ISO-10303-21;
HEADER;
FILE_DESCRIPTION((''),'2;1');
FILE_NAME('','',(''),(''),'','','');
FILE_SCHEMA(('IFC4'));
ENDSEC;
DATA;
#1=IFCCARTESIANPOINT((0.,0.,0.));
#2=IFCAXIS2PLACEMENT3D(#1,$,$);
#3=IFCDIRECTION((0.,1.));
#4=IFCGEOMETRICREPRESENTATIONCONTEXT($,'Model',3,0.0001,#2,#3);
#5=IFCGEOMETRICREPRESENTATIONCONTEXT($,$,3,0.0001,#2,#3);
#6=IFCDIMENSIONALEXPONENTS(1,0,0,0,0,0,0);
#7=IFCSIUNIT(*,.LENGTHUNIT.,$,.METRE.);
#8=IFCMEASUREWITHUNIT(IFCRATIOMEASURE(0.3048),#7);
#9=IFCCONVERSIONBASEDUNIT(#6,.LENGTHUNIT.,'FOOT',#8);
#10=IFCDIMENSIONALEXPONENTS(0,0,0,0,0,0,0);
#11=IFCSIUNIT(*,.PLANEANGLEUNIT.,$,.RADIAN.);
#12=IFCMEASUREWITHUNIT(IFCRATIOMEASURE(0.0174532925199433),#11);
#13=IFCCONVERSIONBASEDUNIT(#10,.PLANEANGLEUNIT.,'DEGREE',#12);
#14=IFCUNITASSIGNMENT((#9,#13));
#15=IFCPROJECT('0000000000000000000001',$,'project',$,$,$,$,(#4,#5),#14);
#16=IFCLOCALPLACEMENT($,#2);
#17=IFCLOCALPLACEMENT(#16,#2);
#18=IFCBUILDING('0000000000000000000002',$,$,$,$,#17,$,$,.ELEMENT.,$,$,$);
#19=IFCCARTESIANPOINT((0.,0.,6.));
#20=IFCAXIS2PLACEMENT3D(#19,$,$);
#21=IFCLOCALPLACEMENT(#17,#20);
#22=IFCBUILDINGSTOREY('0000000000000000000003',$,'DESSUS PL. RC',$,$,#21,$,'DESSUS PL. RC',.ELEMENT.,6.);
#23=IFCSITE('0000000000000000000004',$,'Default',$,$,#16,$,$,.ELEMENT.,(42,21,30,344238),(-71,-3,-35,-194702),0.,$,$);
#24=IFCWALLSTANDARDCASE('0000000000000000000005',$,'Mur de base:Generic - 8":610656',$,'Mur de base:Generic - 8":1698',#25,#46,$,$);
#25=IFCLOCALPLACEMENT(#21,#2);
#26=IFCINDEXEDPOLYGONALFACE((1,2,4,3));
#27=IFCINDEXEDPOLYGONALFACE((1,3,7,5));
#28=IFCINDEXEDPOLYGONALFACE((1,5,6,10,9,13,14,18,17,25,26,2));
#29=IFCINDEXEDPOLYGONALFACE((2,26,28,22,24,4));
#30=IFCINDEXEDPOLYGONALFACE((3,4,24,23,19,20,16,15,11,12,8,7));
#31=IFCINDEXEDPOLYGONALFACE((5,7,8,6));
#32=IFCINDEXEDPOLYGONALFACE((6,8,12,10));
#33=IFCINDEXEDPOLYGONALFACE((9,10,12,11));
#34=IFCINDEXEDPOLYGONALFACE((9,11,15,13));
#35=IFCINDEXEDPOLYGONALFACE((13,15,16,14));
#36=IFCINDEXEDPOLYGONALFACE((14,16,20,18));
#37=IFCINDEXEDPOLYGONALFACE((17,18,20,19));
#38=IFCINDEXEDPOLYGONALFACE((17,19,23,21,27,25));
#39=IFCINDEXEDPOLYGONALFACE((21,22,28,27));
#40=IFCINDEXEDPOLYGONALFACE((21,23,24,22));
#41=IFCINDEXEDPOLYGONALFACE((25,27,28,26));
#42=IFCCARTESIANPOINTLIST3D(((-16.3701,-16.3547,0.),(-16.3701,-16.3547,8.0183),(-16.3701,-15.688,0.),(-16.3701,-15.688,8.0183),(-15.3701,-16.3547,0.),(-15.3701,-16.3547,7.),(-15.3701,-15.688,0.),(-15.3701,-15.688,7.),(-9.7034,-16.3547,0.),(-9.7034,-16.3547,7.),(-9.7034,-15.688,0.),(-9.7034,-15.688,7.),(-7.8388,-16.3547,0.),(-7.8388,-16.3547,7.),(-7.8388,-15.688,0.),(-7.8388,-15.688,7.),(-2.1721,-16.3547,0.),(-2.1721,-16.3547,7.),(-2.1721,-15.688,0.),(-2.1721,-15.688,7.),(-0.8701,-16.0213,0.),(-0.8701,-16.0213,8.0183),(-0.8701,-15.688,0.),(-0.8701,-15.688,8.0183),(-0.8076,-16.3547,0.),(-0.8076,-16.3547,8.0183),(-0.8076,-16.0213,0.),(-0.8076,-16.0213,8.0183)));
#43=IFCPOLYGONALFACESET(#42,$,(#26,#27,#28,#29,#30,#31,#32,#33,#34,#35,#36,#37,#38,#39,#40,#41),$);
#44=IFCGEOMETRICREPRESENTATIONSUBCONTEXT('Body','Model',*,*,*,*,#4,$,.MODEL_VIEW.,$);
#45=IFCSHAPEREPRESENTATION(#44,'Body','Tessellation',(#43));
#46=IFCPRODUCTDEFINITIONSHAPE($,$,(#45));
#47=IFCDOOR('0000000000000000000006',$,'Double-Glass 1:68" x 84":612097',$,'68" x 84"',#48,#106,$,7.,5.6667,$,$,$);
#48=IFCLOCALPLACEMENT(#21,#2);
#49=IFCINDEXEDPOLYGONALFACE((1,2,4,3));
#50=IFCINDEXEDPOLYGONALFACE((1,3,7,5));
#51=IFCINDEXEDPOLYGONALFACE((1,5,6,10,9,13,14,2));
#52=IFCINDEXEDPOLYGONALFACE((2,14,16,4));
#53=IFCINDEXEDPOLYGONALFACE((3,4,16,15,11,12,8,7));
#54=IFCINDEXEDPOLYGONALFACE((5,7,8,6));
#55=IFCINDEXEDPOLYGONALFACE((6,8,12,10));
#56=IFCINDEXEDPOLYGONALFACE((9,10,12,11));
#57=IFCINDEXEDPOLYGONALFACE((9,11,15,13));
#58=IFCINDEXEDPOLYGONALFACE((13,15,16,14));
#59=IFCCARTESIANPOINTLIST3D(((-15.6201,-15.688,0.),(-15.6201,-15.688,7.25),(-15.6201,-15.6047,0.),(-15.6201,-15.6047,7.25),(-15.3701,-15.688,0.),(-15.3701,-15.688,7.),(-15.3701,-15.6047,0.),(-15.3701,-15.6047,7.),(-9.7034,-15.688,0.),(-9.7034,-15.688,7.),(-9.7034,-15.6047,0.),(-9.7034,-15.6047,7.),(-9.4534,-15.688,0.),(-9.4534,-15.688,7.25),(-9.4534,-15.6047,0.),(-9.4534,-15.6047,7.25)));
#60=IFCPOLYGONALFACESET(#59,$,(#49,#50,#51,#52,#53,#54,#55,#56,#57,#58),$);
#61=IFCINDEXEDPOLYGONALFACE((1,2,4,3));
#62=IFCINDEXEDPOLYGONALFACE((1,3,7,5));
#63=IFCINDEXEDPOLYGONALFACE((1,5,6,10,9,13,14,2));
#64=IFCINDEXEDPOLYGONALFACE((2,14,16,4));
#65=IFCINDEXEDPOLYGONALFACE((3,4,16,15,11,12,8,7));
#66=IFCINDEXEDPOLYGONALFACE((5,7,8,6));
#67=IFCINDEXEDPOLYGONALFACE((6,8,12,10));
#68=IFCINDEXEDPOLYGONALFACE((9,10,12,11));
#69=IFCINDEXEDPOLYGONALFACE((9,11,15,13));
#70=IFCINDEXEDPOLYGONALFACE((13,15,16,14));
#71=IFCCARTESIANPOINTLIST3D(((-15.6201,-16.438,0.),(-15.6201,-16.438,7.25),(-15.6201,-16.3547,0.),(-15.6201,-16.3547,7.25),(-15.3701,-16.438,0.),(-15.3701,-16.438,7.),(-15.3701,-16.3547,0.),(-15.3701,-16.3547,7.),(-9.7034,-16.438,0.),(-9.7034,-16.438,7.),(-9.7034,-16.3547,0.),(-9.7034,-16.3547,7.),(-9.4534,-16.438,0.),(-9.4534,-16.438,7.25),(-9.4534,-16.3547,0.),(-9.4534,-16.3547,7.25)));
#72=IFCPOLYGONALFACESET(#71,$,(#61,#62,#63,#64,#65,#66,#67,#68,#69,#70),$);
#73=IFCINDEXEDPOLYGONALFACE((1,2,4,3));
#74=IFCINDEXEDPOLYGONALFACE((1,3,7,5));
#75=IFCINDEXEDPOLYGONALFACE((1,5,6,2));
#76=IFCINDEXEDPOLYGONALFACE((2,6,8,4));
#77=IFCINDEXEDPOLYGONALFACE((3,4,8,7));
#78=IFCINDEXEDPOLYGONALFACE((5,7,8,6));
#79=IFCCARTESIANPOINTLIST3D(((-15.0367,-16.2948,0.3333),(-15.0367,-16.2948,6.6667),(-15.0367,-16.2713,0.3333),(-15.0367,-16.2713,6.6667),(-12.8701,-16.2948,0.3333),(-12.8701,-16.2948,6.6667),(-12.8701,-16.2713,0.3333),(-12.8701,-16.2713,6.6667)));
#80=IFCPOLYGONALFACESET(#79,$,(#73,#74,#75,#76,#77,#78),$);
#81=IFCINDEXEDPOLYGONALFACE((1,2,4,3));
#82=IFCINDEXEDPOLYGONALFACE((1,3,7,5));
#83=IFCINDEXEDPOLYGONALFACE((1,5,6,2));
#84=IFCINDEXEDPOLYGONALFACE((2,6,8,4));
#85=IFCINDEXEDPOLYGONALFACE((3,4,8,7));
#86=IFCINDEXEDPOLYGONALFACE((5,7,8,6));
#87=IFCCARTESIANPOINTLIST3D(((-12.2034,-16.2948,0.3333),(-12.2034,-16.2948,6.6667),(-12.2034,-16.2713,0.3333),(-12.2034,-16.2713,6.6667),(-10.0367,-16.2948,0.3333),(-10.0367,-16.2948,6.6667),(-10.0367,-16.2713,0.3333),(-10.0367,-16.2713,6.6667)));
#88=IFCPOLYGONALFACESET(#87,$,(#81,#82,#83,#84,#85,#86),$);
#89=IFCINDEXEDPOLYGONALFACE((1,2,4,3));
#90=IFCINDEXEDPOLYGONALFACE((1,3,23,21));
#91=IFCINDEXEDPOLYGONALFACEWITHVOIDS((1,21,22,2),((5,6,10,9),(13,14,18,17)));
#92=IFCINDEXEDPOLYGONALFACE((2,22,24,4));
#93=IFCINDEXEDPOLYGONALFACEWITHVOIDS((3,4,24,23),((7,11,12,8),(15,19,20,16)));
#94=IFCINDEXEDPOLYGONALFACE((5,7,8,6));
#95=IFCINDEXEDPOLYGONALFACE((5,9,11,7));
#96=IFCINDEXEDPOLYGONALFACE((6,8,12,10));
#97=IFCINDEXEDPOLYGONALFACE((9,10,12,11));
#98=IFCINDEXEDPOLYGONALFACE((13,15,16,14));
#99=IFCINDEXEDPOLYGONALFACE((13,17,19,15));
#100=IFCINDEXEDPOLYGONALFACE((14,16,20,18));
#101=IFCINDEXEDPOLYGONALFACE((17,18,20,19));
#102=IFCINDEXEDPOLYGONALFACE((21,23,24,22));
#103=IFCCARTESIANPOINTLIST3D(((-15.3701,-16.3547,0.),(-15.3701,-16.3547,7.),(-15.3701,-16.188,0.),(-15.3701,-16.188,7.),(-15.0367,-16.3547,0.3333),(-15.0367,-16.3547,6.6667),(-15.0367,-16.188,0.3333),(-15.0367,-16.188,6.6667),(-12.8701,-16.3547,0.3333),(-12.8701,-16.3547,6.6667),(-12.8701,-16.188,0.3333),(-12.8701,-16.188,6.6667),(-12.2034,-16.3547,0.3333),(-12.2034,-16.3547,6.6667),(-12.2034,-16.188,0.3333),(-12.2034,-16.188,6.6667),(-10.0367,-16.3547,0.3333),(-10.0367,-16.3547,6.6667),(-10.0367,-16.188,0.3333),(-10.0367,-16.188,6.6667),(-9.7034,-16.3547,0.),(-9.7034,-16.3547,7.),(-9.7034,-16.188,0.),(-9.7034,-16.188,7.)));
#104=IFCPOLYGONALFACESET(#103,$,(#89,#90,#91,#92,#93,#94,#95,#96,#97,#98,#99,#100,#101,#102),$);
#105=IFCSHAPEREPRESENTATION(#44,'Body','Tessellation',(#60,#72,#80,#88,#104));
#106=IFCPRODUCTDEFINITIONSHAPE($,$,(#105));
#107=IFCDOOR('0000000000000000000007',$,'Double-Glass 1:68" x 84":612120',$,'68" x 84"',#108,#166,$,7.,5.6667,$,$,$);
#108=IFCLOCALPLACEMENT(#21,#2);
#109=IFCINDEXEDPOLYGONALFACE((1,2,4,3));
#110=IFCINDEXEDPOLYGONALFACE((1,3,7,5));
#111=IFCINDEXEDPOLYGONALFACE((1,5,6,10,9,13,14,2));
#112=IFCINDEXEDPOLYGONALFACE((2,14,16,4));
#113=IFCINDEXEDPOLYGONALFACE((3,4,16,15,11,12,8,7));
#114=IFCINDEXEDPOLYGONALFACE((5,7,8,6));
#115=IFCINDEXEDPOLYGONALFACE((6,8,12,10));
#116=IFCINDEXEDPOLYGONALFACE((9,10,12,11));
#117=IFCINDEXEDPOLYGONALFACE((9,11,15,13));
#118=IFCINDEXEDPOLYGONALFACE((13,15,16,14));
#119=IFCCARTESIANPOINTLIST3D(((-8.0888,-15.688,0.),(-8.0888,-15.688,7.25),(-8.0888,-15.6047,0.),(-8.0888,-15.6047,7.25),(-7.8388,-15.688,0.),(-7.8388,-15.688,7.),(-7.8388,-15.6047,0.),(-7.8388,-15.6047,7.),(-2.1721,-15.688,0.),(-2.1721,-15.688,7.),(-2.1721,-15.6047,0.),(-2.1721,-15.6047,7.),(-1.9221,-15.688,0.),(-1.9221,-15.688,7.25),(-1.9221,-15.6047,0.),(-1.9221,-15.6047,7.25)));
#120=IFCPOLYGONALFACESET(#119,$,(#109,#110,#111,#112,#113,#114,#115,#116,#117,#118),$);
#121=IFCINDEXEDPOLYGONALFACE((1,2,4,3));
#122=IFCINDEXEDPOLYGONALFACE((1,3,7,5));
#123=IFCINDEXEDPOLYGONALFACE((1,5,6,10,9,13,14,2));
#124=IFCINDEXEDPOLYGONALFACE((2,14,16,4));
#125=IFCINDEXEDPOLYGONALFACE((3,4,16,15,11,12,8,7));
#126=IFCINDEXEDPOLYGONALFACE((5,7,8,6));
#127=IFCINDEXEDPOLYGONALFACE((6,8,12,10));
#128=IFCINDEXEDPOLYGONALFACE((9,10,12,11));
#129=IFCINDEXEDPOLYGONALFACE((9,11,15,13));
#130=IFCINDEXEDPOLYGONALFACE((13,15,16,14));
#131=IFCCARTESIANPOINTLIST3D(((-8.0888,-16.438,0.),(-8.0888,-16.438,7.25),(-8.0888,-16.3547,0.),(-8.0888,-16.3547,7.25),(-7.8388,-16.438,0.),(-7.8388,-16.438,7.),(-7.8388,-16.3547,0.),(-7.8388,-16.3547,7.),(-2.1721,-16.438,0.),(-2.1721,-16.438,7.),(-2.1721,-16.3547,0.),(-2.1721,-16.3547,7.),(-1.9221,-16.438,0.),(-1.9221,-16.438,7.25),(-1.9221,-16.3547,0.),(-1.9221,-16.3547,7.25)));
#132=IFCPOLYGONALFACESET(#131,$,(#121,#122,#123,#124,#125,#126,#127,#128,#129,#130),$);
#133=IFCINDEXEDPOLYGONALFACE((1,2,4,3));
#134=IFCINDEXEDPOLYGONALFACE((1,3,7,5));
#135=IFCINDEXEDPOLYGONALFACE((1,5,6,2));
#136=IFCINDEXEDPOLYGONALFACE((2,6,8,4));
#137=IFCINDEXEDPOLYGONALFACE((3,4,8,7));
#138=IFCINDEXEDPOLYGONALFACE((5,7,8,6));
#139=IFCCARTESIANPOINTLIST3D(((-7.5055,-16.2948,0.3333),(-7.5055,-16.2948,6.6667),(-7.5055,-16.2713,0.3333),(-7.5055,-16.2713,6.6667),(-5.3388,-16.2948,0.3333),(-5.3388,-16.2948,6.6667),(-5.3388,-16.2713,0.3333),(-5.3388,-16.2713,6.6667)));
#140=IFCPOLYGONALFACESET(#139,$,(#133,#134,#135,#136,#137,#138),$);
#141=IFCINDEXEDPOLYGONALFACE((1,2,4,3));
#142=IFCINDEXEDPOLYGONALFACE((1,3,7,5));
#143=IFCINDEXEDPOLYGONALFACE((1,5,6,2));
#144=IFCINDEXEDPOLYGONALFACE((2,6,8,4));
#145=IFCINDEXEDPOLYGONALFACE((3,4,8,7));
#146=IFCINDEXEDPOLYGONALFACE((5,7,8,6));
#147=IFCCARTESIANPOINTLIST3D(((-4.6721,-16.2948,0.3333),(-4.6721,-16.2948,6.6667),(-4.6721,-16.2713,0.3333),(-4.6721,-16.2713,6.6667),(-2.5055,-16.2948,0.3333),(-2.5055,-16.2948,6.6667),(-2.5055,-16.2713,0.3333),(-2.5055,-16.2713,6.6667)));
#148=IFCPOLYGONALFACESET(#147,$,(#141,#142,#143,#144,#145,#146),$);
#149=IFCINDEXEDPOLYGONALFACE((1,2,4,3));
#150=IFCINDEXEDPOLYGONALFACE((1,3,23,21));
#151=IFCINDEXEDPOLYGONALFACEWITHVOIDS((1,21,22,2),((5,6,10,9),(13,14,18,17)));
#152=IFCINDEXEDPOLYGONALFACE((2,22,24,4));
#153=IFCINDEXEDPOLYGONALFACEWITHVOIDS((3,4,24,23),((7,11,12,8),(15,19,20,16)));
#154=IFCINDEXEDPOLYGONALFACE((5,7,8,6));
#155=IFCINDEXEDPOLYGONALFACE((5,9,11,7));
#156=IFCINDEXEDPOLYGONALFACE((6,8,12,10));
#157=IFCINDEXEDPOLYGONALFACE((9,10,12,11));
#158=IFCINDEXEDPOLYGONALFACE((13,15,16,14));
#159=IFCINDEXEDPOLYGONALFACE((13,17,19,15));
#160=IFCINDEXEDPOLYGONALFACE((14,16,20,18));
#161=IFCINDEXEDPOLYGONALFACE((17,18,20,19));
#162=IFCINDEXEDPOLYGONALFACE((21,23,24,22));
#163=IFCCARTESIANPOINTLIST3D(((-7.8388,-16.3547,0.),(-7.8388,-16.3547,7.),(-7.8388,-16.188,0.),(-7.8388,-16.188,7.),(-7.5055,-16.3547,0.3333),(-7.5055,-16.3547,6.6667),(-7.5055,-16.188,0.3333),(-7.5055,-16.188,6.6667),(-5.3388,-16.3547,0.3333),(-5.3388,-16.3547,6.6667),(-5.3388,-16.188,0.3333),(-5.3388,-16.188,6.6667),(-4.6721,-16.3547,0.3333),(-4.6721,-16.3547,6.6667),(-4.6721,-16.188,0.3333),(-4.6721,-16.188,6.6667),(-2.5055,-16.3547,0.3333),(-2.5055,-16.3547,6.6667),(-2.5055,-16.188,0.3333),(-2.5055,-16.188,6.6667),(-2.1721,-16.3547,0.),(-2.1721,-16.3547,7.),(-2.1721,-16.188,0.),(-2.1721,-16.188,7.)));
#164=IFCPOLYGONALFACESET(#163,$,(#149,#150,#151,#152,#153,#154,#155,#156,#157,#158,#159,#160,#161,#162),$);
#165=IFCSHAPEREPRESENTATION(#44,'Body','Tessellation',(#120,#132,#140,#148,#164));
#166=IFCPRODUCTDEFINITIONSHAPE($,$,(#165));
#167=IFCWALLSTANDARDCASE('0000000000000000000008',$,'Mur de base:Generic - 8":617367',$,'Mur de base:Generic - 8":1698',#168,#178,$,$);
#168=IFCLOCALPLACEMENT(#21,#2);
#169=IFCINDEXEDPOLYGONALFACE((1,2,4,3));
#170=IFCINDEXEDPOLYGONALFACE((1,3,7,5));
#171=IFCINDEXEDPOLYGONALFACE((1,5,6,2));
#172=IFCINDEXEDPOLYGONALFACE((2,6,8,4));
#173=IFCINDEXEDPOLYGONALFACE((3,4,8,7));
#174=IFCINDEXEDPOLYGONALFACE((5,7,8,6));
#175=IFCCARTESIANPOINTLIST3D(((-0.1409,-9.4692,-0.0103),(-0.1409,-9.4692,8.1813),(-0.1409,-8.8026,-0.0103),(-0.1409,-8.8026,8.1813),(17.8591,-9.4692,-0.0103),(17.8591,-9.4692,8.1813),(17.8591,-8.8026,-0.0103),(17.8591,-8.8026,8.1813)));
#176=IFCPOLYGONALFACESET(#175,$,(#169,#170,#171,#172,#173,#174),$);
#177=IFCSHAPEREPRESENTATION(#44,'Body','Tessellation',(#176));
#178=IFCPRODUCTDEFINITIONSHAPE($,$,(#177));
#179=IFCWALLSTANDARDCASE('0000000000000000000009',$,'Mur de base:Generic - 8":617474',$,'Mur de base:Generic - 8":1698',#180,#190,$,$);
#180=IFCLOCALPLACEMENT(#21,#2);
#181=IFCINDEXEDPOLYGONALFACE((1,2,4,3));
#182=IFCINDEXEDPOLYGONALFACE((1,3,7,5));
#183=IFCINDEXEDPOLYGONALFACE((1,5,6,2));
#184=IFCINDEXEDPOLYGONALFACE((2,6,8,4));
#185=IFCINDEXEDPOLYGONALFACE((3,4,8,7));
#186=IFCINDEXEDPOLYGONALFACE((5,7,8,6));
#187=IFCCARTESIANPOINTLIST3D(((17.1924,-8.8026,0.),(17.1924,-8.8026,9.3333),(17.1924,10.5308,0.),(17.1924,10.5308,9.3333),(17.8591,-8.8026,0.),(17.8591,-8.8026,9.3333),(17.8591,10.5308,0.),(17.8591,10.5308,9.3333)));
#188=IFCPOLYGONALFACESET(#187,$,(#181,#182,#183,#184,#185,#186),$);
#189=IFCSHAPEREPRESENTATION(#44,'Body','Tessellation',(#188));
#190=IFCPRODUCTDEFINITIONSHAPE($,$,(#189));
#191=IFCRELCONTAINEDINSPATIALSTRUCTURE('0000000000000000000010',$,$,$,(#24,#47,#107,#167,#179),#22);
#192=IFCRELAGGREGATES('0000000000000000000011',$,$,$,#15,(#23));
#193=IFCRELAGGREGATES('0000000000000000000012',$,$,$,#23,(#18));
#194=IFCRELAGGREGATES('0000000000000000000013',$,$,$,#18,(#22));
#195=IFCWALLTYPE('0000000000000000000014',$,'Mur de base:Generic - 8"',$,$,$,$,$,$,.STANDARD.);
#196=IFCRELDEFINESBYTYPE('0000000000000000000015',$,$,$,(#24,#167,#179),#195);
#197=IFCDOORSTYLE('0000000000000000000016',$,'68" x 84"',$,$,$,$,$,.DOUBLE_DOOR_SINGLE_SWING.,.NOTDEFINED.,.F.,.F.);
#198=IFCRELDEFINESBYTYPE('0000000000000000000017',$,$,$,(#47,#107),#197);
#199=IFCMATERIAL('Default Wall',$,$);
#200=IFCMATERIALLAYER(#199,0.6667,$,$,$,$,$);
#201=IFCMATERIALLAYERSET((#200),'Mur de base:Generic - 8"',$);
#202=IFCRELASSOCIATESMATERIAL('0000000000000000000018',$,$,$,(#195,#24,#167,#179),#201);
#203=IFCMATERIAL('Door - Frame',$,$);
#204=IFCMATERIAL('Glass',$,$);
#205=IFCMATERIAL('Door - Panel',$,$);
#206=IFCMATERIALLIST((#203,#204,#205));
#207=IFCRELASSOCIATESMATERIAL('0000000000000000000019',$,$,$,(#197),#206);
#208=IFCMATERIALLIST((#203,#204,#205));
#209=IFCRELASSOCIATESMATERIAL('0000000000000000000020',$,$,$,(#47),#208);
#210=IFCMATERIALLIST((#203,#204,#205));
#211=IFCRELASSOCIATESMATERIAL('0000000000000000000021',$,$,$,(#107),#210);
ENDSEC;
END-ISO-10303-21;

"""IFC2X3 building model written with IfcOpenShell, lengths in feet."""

from ifc_helpers import new_model, entity, si_unit, converted_unit, direction, frame, frame_2d, origin, origin_2d_with_axis, place, context, subcontext, project, spatial, polyline, rectangle, outline, extrude, source, transform, mapped, material, material_list, layer, layer_set, layer_usage, type_object, type_shapes, element, fill, save


model = new_model("IFC2X3")

# Units and contexts
model_context = context("Model", 3, precision=0.0001, world=origin(), true_north=direction((0.0, 1.0)))
context_of_model = context(None, 3, precision=0.0001, world=origin(), true_north=direction((0.0, 1.0)))
body_context = subcontext(model_context, "Body", "Model", "MODEL_VIEW")
ifc_project = project(units=[converted_unit("LENGTHUNIT", "FOOT", entity("IfcRatioMeasure", 0.3048), si_unit("LENGTHUNIT", "METRE"), dimensions=[1, 0, 0, 0, 0, 0, 0]), converted_unit("PLANEANGLEUNIT", "DEGREE", entity("IfcRatioMeasure", 0.0174532925199433), si_unit("PLANEANGLEUNIT", "RADIAN"), dimensions=[0, 0, 0, 0, 0, 0, 0])], contexts=[model_context, context_of_model])

# Site, building, storey
site_placement = place(None, origin())
site = spatial("IfcSite", under=ifc_project, at=site_placement, Name="Default", CompositionType="ELEMENT", RefLatitude=(42, 21, 30, 344238), RefLongitude=(-71, -3, -35, -194702), RefElevation=0.0)
building_placement = place(site_placement, origin())
building = spatial("IfcBuilding", under=site, at=building_placement, CompositionType="ELEMENT")
storey_placement = place(building_placement, frame((0.0, 0.0, 6.0)))
storey = spatial("IfcBuildingStorey", under=building, at=storey_placement, Name="DESSUS PL. RC", LongName="DESSUS PL. RC", CompositionType="ELEMENT", Elevation=6.0)

# Shared definitions
ifc_material_1 = material(Name="Default Wall")
ifc_material_2 = material(Name="Door - Frame")
ifc_material_3 = material(Name="Glass")
ifc_material_4 = material(Name="Door - Panel")

# Shared definitions
ifc_layer_1 = layer(ifc_material_1, 0.6667)
ifc_layer_set_1 = layer_set([ifc_layer_1], Name="Mur de base:Generic - 8\"")
wall_type_1 = type_object("IfcWallType", Name="Mur de base:Generic - 8\"", PredefinedType="STANDARD", material=ifc_layer_set_1)

# Wall, openings, doors
ifc_layer_usage_1 = layer_usage(ifc_layer_set_1, "AXIS2", "NEGATIVE", 0.3333)
wall_1_placement = place(storey_placement, frame((-0.8076, -16.0213, 0.0), z_axis=(0.0, 0.0, 1.0), x_axis=(-1.0, 0.0, 0.0)))
wall_1 = element("IfcWallStandardCase", 1, at=wall_1_placement, inside=storey, type_object=wall_type_1, material=ifc_layer_usage_1, Name="Mur de base:Generic - 8\":610656", ObjectType="Mur de base:Generic - 8\":1698", context=body_context, shape_type="SweptSolid", body=[
    extrude(outline(polyline([(0.0625, -0.3333), (15.5625, -0.3333), (15.5625, 0.3333), (0.0, 0.3333), (0.0, 0.0), (0.0625, 0.0), (0.0625, -0.3333)])), origin(), (0.0, 0.0, 1.0), 8.0183),
])
opening_1_placement = place(wall_1_placement, frame((8.8958, -0.3333, 0.0)))
opening_1 = element("IfcOpeningElement", 2, at=opening_1_placement, cuts=wall_1, ObjectType="Opening", context=body_context, shape_type="SweptSolid", body=[
    extrude(rectangle(XDim=5.6667, YDim=7.0, at=frame_2d((3.5, 2.8333), x_axis=(0.0, 1.0))), frame((0.0, 0.0, 0.0), z_axis=(0.0, 1.0, 0.0), x_axis=(0.0, 0.0, 1.0)), (0.0, 0.0, 1.0), 0.6667),
])
opening_2_placement = place(wall_1_placement, frame((1.3646, -0.3333, 0.0)))
opening_2 = element("IfcOpeningElement", 3, at=opening_2_placement, cuts=wall_1, ObjectType="Opening", context=body_context, shape_type="SweptSolid", body=[
    extrude(rectangle(XDim=5.6667, YDim=7.0, at=frame_2d((3.5, 2.8333), x_axis=(0.0, 1.0))), frame((0.0, 0.0, 0.0), z_axis=(0.0, 1.0, 0.0), x_axis=(0.0, 0.0, 1.0)), (0.0, 0.0, 1.0), 0.6667),
])
ifc_material_list_1 = material_list([ifc_material_2, ifc_material_3, ifc_material_4])
ifc_material_list_2 = material_list([ifc_material_2, ifc_material_3, ifc_material_4])
door_style_1 = type_object("IfcDoorStyle", Name="68\" x 84\"", ConstructionType="NOTDEFINED", OperationType="DOUBLE_DOOR_SINGLE_SWING", ParameterTakesPrecedence=False, Sizeable=False, material=ifc_material_list_2)
shared_shape_1 = source(origin(), body_context, "Body", "SweptSolid", [
    extrude(outline(polyline([(-3.0833, -3.5625), (-2.8333, -3.5625), (-2.8333, 3.4375), (2.8333, 3.4375), (2.8333, -3.5625), (3.0833, -3.5625), (3.0833, 3.6875), (-3.0833, 3.6875), (-3.0833, -3.5625)])), frame((2.8333, -0.0833, 3.5625), z_axis=(0.0, 1.0, 0.0), x_axis=(-1.0, 0.0, 0.0)), (0.0, 0.0, 1.0), 0.0833),
    extrude(outline(polyline([(-2.8333, -3.4375), (-2.8333, 3.5625), (-3.0833, 3.5625), (-3.0833, -3.6875), (3.0833, -3.6875), (3.0833, 3.5625), (2.8333, 3.5625), (2.8333, -3.4375), (-2.8333, -3.4375)])), frame((2.8333, 0.6667, 3.5625), z_axis=(0.0, -1.0, 0.0), x_axis=(-1.0, 0.0, 0.0)), (0.0, 0.0, -1.0), 0.0833),
    extrude(rectangle(XDim=0.0234, YDim=2.1667, at=frame_2d((0.0, 0.0), x_axis=(1.0, 0.0))), frame((4.25, 0.5951, 0.3333), z_axis=(0.0, 0.0, 1.0), x_axis=(0.0, 1.0, 0.0)), (0.0, 0.0, 1.0), 6.3333),
    extrude(rectangle(XDim=0.0234, YDim=2.1667, at=origin_2d_with_axis()), frame((1.4167, 0.5951, 0.3333), z_axis=(0.0, 0.0, 1.0), x_axis=(0.0, 1.0, 0.0)), (0.0, 0.0, 1.0), 6.3333),
    extrude(outline(polyline([(-3.5, -2.8333), (3.5, -2.8333), (3.5, 2.8333), (-3.5, 2.8333), (-3.5, -2.8333)]), holes=[polyline([(-3.1667, 0.3333), (-3.1667, 2.5), (3.1667, 2.5), (3.1667, 0.3333), (-3.1667, 0.3333)]), polyline([(-3.1667, -2.5), (-3.1667, -0.3333), (3.1667, -0.3333), (3.1667, -2.5), (-3.1667, -2.5)])]), frame((2.8333, 0.5, 3.5), z_axis=(0.0, 1.0, 0.0), x_axis=(0.0, 0.0, -1.0)), (0.0, 0.0, 1.0), 0.1667),
])
type_shapes(door_style_1, [shared_shape_1])
door_1_placement = place(opening_1_placement, origin())
door_1 = element("IfcDoor", 4, at=door_1_placement, inside=storey, type_object=door_style_1, material=ifc_material_list_1, Name="Double-Glass 1:68\" x 84\":612097", ObjectType="68\" x 84\"", OverallHeight=7.0, OverallWidth=5.6667, context=body_context, shape_type="MappedRepresentation", body=[
    mapped(shared_shape_1, transform((0.0, 0.0, 0.0), scale=1.0)),
])
fill(opening_1, door_1)
ifc_material_list_3 = material_list([ifc_material_2, ifc_material_3, ifc_material_4])
door_2_placement = place(opening_2_placement, origin())
door_2 = element("IfcDoor", 5, at=door_2_placement, inside=storey, type_object=door_style_1, material=ifc_material_list_3, Name="Double-Glass 1:68\" x 84\":612120", ObjectType="68\" x 84\"", OverallHeight=7.0, OverallWidth=5.6667, context=body_context, shape_type="MappedRepresentation", body=[
    mapped(shared_shape_1, transform((0.0, 0.0, 0.0), scale=1.0)),
])
fill(opening_2, door_2)

# Walls
ifc_layer_usage_2 = layer_usage(ifc_layer_set_1, "AXIS2", "NEGATIVE", 0.3333)
wall_2_placement = place(storey_placement, frame((-0.1409, -9.1359, -0.0103)))
element("IfcWallStandardCase", 6, at=wall_2_placement, inside=storey, type_object=wall_type_1, material=ifc_layer_usage_2, Name="Mur de base:Generic - 8\":617367", ObjectType="Mur de base:Generic - 8\":1698", context=body_context, shape_type="SweptSolid", body=[
    extrude(rectangle(XDim=18.0, YDim=0.6667, at=frame_2d((9.0, 0.0), x_axis=(-1.0, 0.0))), origin(), (0.0, 0.0, 1.0), 8.1916),
])
ifc_layer_usage_3 = layer_usage(ifc_layer_set_1, "AXIS2", "NEGATIVE", 0.3333)
wall_3_placement = place(storey_placement, frame((17.5258, -8.8026, 0.0), z_axis=(0.0, 0.0, 1.0), x_axis=(0.0, 1.0, 0.0)))
element("IfcWallStandardCase", 7, at=wall_3_placement, inside=storey, type_object=wall_type_1, material=ifc_layer_usage_3, Name="Mur de base:Generic - 8\":617474", ObjectType="Mur de base:Generic - 8\":1698", context=body_context, shape_type="SweptSolid", body=[
    extrude(rectangle(XDim=19.3333, YDim=0.6667, at=frame_2d((9.6667, 0.0), x_axis=(-1.0, 0.0))), origin(), (0.0, 0.0, 1.0), 9.3333),
])

save(model, "model.ifc")
